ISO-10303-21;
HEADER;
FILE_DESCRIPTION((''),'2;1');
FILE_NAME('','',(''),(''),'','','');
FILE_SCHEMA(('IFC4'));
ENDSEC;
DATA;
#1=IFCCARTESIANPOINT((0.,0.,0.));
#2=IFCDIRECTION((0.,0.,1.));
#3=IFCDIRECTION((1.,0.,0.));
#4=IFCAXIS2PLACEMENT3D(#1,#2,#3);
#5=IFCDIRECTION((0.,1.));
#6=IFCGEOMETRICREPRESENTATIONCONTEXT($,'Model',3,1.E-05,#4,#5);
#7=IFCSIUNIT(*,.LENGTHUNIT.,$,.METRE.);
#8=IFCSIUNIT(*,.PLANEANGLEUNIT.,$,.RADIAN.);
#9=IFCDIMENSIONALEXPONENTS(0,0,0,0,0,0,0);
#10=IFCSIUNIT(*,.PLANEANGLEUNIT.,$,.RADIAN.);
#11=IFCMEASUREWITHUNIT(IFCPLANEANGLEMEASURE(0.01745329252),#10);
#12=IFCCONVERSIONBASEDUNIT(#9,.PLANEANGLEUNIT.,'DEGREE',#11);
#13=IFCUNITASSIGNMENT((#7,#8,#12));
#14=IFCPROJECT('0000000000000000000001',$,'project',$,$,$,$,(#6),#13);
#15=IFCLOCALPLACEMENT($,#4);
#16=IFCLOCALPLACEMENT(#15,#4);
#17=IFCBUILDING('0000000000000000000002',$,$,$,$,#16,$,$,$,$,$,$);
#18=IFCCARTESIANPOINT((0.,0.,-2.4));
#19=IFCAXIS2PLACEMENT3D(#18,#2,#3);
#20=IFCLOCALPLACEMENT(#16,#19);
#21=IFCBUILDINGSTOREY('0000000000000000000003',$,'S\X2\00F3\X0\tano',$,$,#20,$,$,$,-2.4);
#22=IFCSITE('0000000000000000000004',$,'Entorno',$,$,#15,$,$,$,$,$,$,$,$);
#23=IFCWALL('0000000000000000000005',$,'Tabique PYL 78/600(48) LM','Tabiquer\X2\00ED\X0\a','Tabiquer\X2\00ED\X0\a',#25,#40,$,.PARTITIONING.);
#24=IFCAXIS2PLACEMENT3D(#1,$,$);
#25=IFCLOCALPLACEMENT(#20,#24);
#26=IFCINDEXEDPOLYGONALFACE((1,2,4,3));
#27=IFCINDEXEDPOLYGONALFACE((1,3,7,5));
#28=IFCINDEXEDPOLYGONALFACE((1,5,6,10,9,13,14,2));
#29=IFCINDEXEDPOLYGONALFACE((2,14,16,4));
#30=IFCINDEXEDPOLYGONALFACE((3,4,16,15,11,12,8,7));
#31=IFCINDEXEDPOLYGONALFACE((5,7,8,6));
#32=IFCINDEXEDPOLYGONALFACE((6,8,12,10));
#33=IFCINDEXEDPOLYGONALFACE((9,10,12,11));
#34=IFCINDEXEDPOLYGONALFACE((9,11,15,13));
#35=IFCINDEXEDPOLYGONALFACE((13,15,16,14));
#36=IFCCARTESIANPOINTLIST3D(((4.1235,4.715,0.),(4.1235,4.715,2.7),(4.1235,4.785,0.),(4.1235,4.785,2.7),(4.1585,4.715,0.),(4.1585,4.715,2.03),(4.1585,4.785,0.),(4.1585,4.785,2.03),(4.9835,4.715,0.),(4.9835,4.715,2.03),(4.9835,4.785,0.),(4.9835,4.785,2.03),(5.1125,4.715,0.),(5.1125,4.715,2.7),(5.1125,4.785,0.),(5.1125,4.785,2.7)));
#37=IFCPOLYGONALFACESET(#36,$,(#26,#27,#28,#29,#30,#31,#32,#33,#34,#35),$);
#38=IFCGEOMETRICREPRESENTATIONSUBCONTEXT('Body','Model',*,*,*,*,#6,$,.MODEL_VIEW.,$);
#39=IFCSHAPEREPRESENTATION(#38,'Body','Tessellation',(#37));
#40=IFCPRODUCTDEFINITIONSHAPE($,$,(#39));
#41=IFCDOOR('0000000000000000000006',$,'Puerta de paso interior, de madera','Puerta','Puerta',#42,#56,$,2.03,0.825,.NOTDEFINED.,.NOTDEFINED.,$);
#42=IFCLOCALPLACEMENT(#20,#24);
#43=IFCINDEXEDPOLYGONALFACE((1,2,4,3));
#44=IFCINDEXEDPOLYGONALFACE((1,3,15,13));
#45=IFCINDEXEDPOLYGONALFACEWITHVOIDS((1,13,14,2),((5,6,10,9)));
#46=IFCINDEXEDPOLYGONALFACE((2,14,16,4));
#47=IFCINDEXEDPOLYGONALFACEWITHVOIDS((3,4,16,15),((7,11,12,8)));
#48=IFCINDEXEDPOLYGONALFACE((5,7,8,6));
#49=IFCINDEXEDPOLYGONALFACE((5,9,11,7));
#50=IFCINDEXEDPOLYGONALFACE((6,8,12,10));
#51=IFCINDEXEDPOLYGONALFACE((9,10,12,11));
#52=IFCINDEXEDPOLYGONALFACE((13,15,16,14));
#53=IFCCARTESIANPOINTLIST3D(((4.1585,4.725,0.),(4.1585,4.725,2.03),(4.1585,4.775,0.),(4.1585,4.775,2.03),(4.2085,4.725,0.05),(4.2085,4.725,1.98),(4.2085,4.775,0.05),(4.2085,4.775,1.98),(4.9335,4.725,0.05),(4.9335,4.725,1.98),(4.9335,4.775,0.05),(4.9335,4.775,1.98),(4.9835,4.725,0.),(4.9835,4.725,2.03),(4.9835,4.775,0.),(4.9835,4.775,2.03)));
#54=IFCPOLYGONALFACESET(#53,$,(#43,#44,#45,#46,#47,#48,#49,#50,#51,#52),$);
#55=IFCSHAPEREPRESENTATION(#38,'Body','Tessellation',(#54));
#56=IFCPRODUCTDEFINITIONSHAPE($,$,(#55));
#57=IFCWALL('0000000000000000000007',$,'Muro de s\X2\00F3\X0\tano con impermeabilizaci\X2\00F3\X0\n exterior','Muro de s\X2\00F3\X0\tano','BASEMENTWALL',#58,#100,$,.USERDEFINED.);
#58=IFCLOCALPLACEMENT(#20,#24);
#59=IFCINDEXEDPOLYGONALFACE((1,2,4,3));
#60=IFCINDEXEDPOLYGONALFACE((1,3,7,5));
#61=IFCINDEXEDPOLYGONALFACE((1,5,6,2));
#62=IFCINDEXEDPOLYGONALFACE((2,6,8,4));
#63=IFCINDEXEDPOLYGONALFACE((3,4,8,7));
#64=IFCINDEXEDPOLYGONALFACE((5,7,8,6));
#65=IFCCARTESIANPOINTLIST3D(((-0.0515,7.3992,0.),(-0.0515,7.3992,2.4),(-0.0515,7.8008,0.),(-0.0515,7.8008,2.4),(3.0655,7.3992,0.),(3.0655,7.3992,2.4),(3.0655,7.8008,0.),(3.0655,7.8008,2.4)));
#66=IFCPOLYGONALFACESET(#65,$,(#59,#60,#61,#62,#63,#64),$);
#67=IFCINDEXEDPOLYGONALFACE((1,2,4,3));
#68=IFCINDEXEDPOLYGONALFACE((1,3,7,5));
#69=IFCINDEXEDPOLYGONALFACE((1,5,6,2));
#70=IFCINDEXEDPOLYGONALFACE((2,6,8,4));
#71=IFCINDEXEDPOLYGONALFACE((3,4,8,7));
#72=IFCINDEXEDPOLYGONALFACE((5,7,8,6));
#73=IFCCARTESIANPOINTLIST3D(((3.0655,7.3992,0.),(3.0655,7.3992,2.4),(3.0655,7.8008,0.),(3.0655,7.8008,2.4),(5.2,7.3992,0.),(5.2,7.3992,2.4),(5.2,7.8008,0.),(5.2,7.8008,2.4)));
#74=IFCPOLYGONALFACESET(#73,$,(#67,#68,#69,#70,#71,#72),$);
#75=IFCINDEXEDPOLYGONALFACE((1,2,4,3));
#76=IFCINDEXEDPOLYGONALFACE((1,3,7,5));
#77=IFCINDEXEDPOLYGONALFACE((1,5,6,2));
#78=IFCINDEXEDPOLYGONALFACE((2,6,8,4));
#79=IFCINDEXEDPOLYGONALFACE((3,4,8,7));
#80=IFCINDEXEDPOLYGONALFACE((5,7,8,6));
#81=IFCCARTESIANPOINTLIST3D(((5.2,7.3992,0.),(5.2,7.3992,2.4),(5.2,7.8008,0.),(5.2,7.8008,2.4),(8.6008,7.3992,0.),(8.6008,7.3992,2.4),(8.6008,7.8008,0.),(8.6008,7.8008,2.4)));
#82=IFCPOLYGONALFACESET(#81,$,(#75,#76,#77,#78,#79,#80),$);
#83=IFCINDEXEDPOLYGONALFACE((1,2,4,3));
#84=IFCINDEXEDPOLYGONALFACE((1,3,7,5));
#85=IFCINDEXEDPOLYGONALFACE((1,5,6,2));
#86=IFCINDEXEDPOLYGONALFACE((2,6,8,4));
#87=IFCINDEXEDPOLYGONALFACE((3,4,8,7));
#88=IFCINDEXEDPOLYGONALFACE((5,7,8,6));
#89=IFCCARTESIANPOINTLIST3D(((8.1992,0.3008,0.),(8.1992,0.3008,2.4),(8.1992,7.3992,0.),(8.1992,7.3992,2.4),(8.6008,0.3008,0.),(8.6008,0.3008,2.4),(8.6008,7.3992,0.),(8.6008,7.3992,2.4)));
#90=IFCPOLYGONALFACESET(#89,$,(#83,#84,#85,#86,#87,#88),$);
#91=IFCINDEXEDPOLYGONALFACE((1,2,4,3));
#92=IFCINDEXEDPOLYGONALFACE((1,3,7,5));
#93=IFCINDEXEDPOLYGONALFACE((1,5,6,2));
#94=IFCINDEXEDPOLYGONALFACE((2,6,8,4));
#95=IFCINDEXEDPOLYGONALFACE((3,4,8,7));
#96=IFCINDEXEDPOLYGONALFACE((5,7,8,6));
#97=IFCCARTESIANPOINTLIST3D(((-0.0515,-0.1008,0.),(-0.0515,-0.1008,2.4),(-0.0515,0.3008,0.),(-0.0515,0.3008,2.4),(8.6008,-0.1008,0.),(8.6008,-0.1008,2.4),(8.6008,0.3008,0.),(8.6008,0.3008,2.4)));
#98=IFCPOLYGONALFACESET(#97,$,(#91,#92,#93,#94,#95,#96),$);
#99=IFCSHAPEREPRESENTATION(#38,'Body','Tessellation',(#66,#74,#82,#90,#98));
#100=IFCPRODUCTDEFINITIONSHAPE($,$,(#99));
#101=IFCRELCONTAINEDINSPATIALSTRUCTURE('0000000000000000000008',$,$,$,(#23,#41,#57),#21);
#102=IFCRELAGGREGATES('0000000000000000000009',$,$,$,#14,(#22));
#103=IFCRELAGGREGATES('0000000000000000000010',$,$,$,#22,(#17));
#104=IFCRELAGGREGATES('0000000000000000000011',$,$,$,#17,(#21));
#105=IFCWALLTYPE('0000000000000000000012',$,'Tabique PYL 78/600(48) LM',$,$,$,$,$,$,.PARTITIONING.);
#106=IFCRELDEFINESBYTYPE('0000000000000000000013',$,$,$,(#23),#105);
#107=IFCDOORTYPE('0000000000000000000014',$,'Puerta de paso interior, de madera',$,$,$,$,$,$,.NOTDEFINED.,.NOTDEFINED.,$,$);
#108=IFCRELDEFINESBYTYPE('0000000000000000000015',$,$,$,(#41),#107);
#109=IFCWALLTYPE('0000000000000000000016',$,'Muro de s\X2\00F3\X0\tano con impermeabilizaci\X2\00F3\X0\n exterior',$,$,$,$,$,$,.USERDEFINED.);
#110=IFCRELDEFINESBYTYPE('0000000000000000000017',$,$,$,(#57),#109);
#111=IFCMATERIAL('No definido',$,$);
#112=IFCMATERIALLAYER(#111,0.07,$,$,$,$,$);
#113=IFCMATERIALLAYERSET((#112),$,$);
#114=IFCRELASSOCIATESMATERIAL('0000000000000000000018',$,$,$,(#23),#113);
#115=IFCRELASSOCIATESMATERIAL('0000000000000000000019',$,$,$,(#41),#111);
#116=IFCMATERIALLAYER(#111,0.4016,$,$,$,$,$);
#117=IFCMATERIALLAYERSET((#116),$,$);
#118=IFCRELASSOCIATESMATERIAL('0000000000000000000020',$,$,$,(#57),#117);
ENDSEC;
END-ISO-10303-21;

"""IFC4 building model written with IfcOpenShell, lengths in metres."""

from ifc_helpers import new_model, entity, si_unit, converted_unit, direction, frame, origin_with_axes, origin_2d_with_axis, place, context, subcontext, project, spatial, rectangle, hollow_rectangle, extrude, shape, material, layer, layer_set, layer_usage, type_object, element, fill, save


model = new_model("IFC4")

# Units and contexts
model_context = context("Model", 3, precision=1e-05, world=origin_with_axes(), true_north=direction((0.0, 1.0)))
body_context = subcontext(model_context, "Body", "Model", "MODEL_VIEW")
footprint_context = subcontext(model_context, "FootPrint", "Model", "MODEL_VIEW")
ifc_project = project(units=[si_unit("LENGTHUNIT", "METRE"), si_unit("PLANEANGLEUNIT", "RADIAN"), converted_unit("PLANEANGLEUNIT", "DEGREE", entity("IfcPlaneAngleMeasure", 0.01745329252), si_unit("PLANEANGLEUNIT", "RADIAN"), dimensions=[0, 0, 0, 0, 0, 0, 0])], contexts=[model_context])

# Site, building, storey
site_placement = place(None, origin_with_axes())
site = spatial("IfcSite", under=ifc_project, at=site_placement, Name="Entorno")
building_placement = place(site_placement, origin_with_axes())
building = spatial("IfcBuilding", under=site, at=building_placement)
storey_placement = place(building_placement, frame((0.0, 0.0, -2.4), z_axis=(0.0, 0.0, 1.0), x_axis=(1.0, 0.0, 0.0)))
storey = spatial("IfcBuildingStorey", under=building, at=storey_placement, Name="Sótano", Elevation=-2.4)

# Shared definitions
ifc_material = material(Name="No definido")

# Shared definitions
wall_type_1 = type_object("IfcWallType", Name="Tabique PYL 78/600(48) LM", PredefinedType="PARTITIONING")

# Wall, opening, door
ifc_layer_1 = layer(ifc_material, 0.07)
ifc_layer_set_1 = layer_set([ifc_layer_1])
ifc_layer_usage_1 = layer_usage(ifc_layer_set_1, "AXIS2", "POSITIVE", -0.035)
wall_1_placement = place(storey_placement, frame((4.1585, 4.75, 0.0), z_axis=(0.0, 0.0, 1.0), x_axis=(1.0, 0.0, 0.0)))
cartesian_point_1 = entity("IfcCartesianPoint", [-0.4945, -1.35])
cartesian_point_2 = entity("IfcCartesianPoint", [-0.4945, -1.35])
wall_1 = element("IfcWall", 1, at=wall_1_placement, inside=storey, type_object=wall_type_1, material=ifc_layer_usage_1, Name="Tabique PYL 78/600(48) LM", Description="Tabiquería", ObjectType="Tabiquería", PredefinedType="PARTITIONING", context=body_context, shape_type="SolidModel", body=[
    entity("IfcExtrudedAreaSolidTapered", entity("IfcArbitraryClosedProfileDef", "AREA", None, entity("IfcPolyline", [cartesian_point_1, entity("IfcCartesianPoint", [0.4945, -1.35]), entity("IfcCartesianPoint", [0.4945, 1.35]), entity("IfcCartesianPoint", [-0.4945, 1.35]), cartesian_point_1])), entity("IfcAxis2Placement3D", entity("IfcCartesianPoint", [0.4595, 0.035, 1.35]), entity("IfcDirection", [0.0, -1.0, 0.0]), entity("IfcDirection", [1.0, 0.0, 0.0])), entity("IfcDirection", [0.0, 0.0, 1.0]), 0.07, entity("IfcArbitraryClosedProfileDef", "AREA", None, entity("IfcPolyline", [cartesian_point_2, entity("IfcCartesianPoint", [0.4945, -1.35]), entity("IfcCartesianPoint", [0.4945, 1.35]), entity("IfcCartesianPoint", [-0.4945, 1.35]), cartesian_point_2]))),
])
opening_1_placement = place(wall_1_placement, frame((0.4125, 0.0, 1.015), z_axis=(0.0, 0.0, 1.0), x_axis=(1.0, 0.0, 0.0)))
cartesian_point_3 = entity("IfcCartesianPoint", [-0.4125, -0.035])
opening_1 = element("IfcOpeningElement", 2, at=opening_1_placement, cuts=wall_1, ObjectType="No definido", PredefinedType="OPENING", shapes=[
    shape(body_context, "Body", "SweptSolid", [extrude(rectangle(XDim=2.03, YDim=0.825, at=origin_2d_with_axis()), frame((0.0, -0.035, 0.0), z_axis=(0.0, 1.0, 0.0), x_axis=(0.0, 0.0, 1.0)), (0.0, 0.0, 1.0), 0.07)]),
    shape(footprint_context, "FootPrint", "GeometricCurveSet", [entity("IfcGeometricCurveSet", [entity("IfcPolyline", [cartesian_point_3, entity("IfcCartesianPoint", [0.4125, -0.035]), entity("IfcCartesianPoint", [0.4125, 0.035]), entity("IfcCartesianPoint", [-0.4125, 0.035]), cartesian_point_3])])]),
])
door_type_1 = type_object("IfcDoorType", Name="Puerta de paso interior, de madera", OperationType="NOTDEFINED", PredefinedType="NOTDEFINED")
door_1_placement = place(opening_1_placement, origin_with_axes())
door_1 = element("IfcDoor", 3, at=door_1_placement, inside=storey, type_object=door_type_1, material=ifc_material, Name="Puerta de paso interior, de madera", Description="Puerta", ObjectType="Puerta", OperationType="NOTDEFINED", OverallHeight=2.03, OverallWidth=0.825, PredefinedType="NOTDEFINED", context=body_context, shape_type="SweptSolid", body=[
    extrude(hollow_rectangle(XDim=0.825, YDim=2.03, WallThickness=0.05, InnerFilletRadius=0.0, OuterFilletRadius=0.0, at=origin_2d_with_axis()), frame((0.0, 0.025, 0.0), z_axis=(0.0, -1.0, 0.0), x_axis=(1.0, 0.0, 0.0)), (0.0, 0.0, 1.0), 0.05),
])
fill(opening_1, door_1)

# Wall
ifc_layer_2 = layer(ifc_material, 0.4016)
ifc_layer_set_2 = layer_set([ifc_layer_2])
ifc_layer_usage_2 = layer_usage(ifc_layer_set_2, "AXIS2", "POSITIVE", -0.2008)
wall_type_2 = type_object("IfcWallType", Name="Muro de sótano con impermeabilización exterior", PredefinedType="USERDEFINED")
wall_2_placement = place(storey_placement, frame((0.1, 7.6, 0.0), z_axis=(0.0, 0.0, 1.0), x_axis=(1.0, 0.0, 0.0)))
cartesian_point_4 = entity("IfcCartesianPoint", [-1.5585, -1.2])
cartesian_point_5 = entity("IfcCartesianPoint", [-1.5585, -1.2])
cartesian_point_6 = entity("IfcCartesianPoint", [-1.0673, -1.2])
cartesian_point_7 = entity("IfcCartesianPoint", [-1.0673, -1.2])
cartesian_point_8 = entity("IfcCartesianPoint", [-1.7004, -1.2])
cartesian_point_9 = entity("IfcCartesianPoint", [-1.7004, -1.2])
cartesian_point_10 = entity("IfcCartesianPoint", [-3.5492, -1.2])
cartesian_point_11 = entity("IfcCartesianPoint", [-3.5492, -1.2])
cartesian_point_12 = entity("IfcCartesianPoint", [-4.3262, -1.2])
cartesian_point_13 = entity("IfcCartesianPoint", [-4.3262, -1.2])
element("IfcWall", 4, at=wall_2_placement, inside=storey, type_object=wall_type_2, material=ifc_layer_usage_2, Name="Muro de sótano con impermeabilización exterior", Description="Muro de sótano", ObjectType="BASEMENTWALL", PredefinedType="USERDEFINED", context=body_context, shape_type="SolidModel", body=[
    entity("IfcExtrudedAreaSolidTapered", entity("IfcArbitraryClosedProfileDef", "AREA", None, entity("IfcPolyline", [cartesian_point_4, entity("IfcCartesianPoint", [1.5585, -1.2]), entity("IfcCartesianPoint", [1.5585, 1.2]), entity("IfcCartesianPoint", [-1.5585, 1.2]), cartesian_point_4])), entity("IfcAxis2Placement3D", entity("IfcCartesianPoint", [1.407, 0.2008, 1.2]), entity("IfcDirection", [0.0, -1.0, 0.0]), entity("IfcDirection", [1.0, 0.0, 0.0])), entity("IfcDirection", [0.0, 0.0, 1.0]), 0.4016, entity("IfcArbitraryClosedProfileDef", "AREA", None, entity("IfcPolyline", [cartesian_point_5, entity("IfcCartesianPoint", [1.5585, -1.2]), entity("IfcCartesianPoint", [1.5585, 1.2]), entity("IfcCartesianPoint", [-1.5585, 1.2]), cartesian_point_5]))),
    entity("IfcExtrudedAreaSolidTapered", entity("IfcArbitraryClosedProfileDef", "AREA", None, entity("IfcPolyline", [cartesian_point_6, entity("IfcCartesianPoint", [1.0673, -1.2]), entity("IfcCartesianPoint", [1.0673, 1.2]), entity("IfcCartesianPoint", [-1.0673, 1.2]), cartesian_point_6])), entity("IfcAxis2Placement3D", entity("IfcCartesianPoint", [4.0328, 0.2008, 1.2]), entity("IfcDirection", [0.0, -1.0, 0.0]), entity("IfcDirection", [1.0, 0.0, 0.0])), entity("IfcDirection", [0.0, 0.0, 1.0]), 0.4016, entity("IfcArbitraryClosedProfileDef", "AREA", None, entity("IfcPolyline", [cartesian_point_7, entity("IfcCartesianPoint", [1.0673, -1.2]), entity("IfcCartesianPoint", [1.0673, 1.2]), entity("IfcCartesianPoint", [-1.0673, 1.2]), cartesian_point_7]))),
    entity("IfcExtrudedAreaSolidTapered", entity("IfcArbitraryClosedProfileDef", "AREA", None, entity("IfcPolyline", [cartesian_point_8, entity("IfcCartesianPoint", [1.7004, -1.2]), entity("IfcCartesianPoint", [1.7004, 1.2]), entity("IfcCartesianPoint", [-1.7004, 1.2]), cartesian_point_8])), entity("IfcAxis2Placement3D", entity("IfcCartesianPoint", [6.8004, 0.2008, 1.2]), entity("IfcDirection", [0.0, -1.0, 0.0]), entity("IfcDirection", [1.0, 0.0, 0.0])), entity("IfcDirection", [0.0, 0.0, 1.0]), 0.4016, entity("IfcArbitraryClosedProfileDef", "AREA", None, entity("IfcPolyline", [cartesian_point_9, entity("IfcCartesianPoint", [1.7004, -1.2]), entity("IfcCartesianPoint", [1.7004, 1.2]), entity("IfcCartesianPoint", [-1.7004, 1.2]), cartesian_point_9]))),
    entity("IfcExtrudedAreaSolidTapered", entity("IfcArbitraryClosedProfileDef", "AREA", None, entity("IfcPolyline", [cartesian_point_10, entity("IfcCartesianPoint", [3.5492, -1.2]), entity("IfcCartesianPoint", [3.5492, 1.2]), entity("IfcCartesianPoint", [-3.5492, 1.2]), cartesian_point_10])), entity("IfcAxis2Placement3D", entity("IfcCartesianPoint", [8.5008, -3.75, 1.2]), entity("IfcDirection", [-1.0, 0.0, 0.0]), entity("IfcDirection", [0.0, -1.0, 0.0])), entity("IfcDirection", [0.0, 0.0, 1.0]), 0.4016, entity("IfcArbitraryClosedProfileDef", "AREA", None, entity("IfcPolyline", [cartesian_point_11, entity("IfcCartesianPoint", [3.5492, -1.2]), entity("IfcCartesianPoint", [3.5492, 1.2]), entity("IfcCartesianPoint", [-3.5492, 1.2]), cartesian_point_11]))),
    entity("IfcExtrudedAreaSolidTapered", entity("IfcArbitraryClosedProfileDef", "AREA", None, entity("IfcPolyline", [cartesian_point_12, entity("IfcCartesianPoint", [4.3262, -1.2]), entity("IfcCartesianPoint", [4.3262, 1.2]), entity("IfcCartesianPoint", [-4.3262, 1.2]), cartesian_point_12])), entity("IfcAxis2Placement3D", entity("IfcCartesianPoint", [4.1746, -7.7008, 1.2]), entity("IfcDirection", [0.0, 1.0, 0.0]), entity("IfcDirection", [-1.0, 0.0, 0.0])), entity("IfcDirection", [0.0, 0.0, 1.0]), 0.4016, entity("IfcArbitraryClosedProfileDef", "AREA", None, entity("IfcPolyline", [cartesian_point_13, entity("IfcCartesianPoint", [4.3262, -1.2]), entity("IfcCartesianPoint", [4.3262, 1.2]), entity("IfcCartesianPoint", [-4.3262, 1.2]), cartesian_point_13]))),
])

save(model, "model.ifc")
